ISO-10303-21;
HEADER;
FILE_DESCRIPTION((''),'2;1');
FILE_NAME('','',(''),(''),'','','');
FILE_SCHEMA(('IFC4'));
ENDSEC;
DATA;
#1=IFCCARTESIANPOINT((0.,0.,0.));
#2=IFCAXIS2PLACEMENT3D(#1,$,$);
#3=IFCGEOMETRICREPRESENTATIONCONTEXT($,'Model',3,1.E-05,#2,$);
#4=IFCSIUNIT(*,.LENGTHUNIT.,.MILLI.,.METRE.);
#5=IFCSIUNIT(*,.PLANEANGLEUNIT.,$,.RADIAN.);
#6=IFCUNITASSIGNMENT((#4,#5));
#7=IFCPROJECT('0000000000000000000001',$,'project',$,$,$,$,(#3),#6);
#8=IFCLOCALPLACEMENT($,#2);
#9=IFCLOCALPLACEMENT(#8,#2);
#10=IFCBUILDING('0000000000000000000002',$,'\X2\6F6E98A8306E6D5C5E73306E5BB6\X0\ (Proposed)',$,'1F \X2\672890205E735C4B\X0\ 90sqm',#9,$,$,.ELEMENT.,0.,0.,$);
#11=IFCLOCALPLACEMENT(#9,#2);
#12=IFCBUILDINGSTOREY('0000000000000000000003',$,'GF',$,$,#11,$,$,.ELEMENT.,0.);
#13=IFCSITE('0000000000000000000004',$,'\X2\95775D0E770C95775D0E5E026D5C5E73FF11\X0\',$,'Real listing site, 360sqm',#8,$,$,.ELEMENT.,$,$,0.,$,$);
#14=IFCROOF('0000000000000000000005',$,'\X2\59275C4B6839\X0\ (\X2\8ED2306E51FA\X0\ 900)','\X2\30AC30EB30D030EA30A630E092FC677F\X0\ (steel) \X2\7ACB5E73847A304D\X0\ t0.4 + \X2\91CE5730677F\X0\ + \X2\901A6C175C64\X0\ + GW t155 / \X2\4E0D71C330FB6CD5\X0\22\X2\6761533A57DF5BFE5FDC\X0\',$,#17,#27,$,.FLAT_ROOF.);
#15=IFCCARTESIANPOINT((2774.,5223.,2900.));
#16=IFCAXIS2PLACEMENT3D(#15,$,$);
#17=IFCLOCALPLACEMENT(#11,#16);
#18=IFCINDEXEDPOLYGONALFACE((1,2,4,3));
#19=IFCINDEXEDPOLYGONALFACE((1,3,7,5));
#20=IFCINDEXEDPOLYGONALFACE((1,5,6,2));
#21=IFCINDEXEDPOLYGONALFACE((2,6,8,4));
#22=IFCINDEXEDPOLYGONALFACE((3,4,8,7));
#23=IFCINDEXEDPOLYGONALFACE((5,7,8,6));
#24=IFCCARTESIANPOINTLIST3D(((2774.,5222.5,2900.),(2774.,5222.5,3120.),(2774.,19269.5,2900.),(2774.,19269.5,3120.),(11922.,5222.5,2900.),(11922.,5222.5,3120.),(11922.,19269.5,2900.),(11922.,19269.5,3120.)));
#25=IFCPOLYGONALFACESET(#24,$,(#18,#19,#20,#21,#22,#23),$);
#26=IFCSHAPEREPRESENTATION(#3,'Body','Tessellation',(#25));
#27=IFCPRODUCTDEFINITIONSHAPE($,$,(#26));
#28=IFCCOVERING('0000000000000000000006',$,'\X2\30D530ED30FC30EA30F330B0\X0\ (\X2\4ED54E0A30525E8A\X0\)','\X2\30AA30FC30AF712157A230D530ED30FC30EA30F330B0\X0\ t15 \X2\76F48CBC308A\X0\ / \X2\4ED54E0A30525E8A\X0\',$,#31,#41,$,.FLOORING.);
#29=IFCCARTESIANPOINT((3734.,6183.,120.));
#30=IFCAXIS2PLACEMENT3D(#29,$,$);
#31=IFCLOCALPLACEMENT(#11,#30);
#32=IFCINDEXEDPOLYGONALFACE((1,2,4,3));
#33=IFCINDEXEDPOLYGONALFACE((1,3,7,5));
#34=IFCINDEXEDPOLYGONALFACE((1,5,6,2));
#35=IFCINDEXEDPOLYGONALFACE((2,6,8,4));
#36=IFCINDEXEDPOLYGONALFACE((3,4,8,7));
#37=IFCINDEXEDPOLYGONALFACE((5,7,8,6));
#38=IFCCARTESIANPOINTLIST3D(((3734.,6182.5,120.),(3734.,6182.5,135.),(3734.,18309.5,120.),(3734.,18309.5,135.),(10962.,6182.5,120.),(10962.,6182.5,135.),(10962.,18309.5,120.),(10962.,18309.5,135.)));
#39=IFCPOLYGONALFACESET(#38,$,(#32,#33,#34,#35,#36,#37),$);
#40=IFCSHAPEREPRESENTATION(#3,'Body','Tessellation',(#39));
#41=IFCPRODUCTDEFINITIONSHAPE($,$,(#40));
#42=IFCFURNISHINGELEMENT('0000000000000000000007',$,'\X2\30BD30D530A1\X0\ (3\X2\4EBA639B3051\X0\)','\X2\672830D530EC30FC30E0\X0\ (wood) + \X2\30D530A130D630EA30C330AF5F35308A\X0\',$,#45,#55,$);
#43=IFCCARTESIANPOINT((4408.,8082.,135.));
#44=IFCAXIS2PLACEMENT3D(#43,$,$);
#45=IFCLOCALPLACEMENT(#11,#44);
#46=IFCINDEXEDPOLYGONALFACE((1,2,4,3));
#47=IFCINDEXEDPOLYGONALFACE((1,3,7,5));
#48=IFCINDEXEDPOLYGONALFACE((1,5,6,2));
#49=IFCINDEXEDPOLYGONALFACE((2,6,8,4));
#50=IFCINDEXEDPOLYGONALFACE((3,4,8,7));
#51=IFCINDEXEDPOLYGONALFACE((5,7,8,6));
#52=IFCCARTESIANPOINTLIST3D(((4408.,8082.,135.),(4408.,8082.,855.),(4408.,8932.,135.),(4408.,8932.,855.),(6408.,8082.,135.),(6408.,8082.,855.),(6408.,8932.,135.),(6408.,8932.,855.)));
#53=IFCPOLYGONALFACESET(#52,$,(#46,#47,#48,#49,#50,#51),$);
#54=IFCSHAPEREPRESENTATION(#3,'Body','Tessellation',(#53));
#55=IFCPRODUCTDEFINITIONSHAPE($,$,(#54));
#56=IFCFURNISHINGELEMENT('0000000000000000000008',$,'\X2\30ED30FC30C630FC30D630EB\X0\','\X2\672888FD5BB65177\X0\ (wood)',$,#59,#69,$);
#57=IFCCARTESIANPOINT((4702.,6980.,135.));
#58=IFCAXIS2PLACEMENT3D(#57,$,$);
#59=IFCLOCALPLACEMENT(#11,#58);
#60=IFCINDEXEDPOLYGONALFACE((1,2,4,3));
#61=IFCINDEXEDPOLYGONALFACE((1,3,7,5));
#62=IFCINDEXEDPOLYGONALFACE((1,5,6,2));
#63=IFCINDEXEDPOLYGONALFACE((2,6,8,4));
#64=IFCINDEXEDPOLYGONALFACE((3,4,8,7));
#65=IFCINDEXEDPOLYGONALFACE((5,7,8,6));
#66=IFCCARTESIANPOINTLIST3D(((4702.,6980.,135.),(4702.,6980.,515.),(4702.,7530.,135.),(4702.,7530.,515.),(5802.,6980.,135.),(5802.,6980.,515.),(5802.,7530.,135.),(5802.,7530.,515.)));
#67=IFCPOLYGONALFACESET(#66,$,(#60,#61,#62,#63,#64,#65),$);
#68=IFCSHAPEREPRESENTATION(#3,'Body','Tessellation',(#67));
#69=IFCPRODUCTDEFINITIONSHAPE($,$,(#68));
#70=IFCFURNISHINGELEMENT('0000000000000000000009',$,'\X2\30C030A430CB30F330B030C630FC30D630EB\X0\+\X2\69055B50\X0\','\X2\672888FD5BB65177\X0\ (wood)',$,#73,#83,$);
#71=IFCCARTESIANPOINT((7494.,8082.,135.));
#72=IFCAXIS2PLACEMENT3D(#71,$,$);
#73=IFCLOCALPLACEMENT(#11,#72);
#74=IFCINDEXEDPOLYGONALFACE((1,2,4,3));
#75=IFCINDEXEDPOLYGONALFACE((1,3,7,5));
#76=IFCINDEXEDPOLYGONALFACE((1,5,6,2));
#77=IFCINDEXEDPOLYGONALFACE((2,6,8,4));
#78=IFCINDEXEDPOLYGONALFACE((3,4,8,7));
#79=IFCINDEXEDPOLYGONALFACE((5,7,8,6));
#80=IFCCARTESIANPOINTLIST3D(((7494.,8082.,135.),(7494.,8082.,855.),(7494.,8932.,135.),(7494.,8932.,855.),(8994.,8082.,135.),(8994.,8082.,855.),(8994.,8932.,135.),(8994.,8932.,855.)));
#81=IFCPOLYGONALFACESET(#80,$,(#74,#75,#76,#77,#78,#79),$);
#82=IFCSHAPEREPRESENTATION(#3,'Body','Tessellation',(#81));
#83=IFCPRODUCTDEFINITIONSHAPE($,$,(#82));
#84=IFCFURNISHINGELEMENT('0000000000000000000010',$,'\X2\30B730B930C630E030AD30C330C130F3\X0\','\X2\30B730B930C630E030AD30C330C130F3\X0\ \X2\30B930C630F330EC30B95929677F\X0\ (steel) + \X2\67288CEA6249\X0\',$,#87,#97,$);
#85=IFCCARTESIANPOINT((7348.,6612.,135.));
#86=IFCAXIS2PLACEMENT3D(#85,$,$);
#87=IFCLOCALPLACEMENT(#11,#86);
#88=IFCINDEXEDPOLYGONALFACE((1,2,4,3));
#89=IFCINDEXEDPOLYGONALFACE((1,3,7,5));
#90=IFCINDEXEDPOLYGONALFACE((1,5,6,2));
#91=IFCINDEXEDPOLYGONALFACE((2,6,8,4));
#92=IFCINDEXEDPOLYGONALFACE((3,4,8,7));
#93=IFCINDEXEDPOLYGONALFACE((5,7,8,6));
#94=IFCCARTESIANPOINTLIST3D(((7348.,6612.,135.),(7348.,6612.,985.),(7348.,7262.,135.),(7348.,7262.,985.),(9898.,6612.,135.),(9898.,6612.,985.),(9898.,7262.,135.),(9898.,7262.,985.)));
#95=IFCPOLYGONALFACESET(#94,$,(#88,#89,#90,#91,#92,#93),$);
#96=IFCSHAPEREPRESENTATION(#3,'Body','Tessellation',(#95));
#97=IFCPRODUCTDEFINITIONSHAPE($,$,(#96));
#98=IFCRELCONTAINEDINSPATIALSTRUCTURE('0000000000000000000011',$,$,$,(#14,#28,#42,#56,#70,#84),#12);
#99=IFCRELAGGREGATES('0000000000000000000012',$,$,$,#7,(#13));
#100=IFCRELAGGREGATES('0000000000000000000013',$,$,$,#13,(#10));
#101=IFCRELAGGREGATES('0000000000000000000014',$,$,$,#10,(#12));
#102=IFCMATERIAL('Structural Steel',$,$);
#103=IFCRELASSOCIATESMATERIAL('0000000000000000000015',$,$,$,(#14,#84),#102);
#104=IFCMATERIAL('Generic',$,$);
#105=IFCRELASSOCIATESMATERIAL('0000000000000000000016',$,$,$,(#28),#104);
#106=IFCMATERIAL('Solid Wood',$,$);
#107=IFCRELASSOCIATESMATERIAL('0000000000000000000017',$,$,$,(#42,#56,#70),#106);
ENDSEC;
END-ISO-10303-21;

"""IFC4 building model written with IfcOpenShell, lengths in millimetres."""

from ifc_helpers import new_model, si_unit, frame, frame_2d, origin, place, context, project, spatial, rectangle, extrude, material, element, save


model = new_model("IFC4")

# Units and contexts
model_context = context("Model", 3, precision=1e-05, world=origin())
ifc_project = project(units=[si_unit("LENGTHUNIT", "METRE", prefix="MILLI"), si_unit("PLANEANGLEUNIT", "RADIAN")], contexts=[model_context])

# Site, building, storey
site_placement = place(None, origin())
site = spatial("IfcSite", under=ifc_project, at=site_placement, Name="長崎県長崎市浜平１", ObjectType="Real listing site, 360sqm", CompositionType="ELEMENT", RefElevation=0.0)
building_placement = place(site_placement, origin())
building = spatial("IfcBuilding", under=site, at=building_placement, Name="潮風の浜平の家 (Proposed)", ObjectType="1F 木造平屋 90sqm", CompositionType="ELEMENT", ElevationOfRefHeight=0.0, ElevationOfTerrain=0.0)
storey_placement = place(building_placement, origin())
storey = spatial("IfcBuildingStorey", under=building, at=storey_placement, Name="GF", CompositionType="ELEMENT", Elevation=0.0)

# Shared definitions
ifc_material_1 = material(Name="Solid Wood")

# Roof
ifc_material_2 = material(Name="Structural Steel")
roof_placement = place(storey_placement, frame((2774.0, 5223.0, 2900.0)))
element("IfcRoof", 1, at=roof_placement, inside=storey, material=ifc_material_2, Name="大屋根 (軒の出 900)", Description="ガルバリウム鋼板 (steel) 立平葺き t0.4 + 野地板 + 通気層 + GW t155 / 不燃・法22条区域対応", PredefinedType="FLAT_ROOF", context=model_context, shape_type="SweptSolid", body=[
    extrude(rectangle(XDim=9148.0, YDim=14047.0, at=frame_2d((4574.0, 7023.0))), frame((2774.0, 5223.0, 2900.0)), (0.0, 0.0, 1.0), 220.0),
])

# Covering
ifc_material_3 = material(Name="Generic")
covering_placement = place(storey_placement, frame((3734.0, 6183.0, 120.0)))
element("IfcCovering", 2, at=covering_placement, inside=storey, material=ifc_material_3, Name="フローリング (仕上げ床)", Description="オーク無垢フローリング t15 直貼り / 仕上げ床", PredefinedType="FLOORING", context=model_context, shape_type="SweptSolid", body=[
    extrude(rectangle(XDim=7228.0, YDim=12127.0, at=frame_2d((3614.0, 6063.0))), frame((3734.0, 6183.0, 120.0)), (0.0, 0.0, 1.0), 15.0),
])

# Furnishing elements
furnishing_1_placement = place(storey_placement, frame((4408.0, 8082.0, 135.0)))
element("IfcFurnishingElement", 3, at=furnishing_1_placement, inside=storey, material=ifc_material_1, Name="ソファ (3人掛け)", Description="木フレーム (wood) + ファブリック張り", context=model_context, shape_type="SweptSolid", body=[
    extrude(rectangle(XDim=2000.0, YDim=850.0, at=frame_2d((1000.0, 425.0))), frame((4408.0, 8082.0, 135.0)), (0.0, 0.0, 1.0), 720.0),
])
furnishing_2_placement = place(storey_placement, frame((4702.0, 6980.0, 135.0)))
element("IfcFurnishingElement", 4, at=furnishing_2_placement, inside=storey, material=ifc_material_1, Name="ローテーブル", Description="木製家具 (wood)", context=model_context, shape_type="SweptSolid", body=[
    extrude(rectangle(XDim=1100.0, YDim=550.0, at=frame_2d((550.0, 275.0))), frame((4702.0, 6980.0, 135.0)), (0.0, 0.0, 1.0), 380.0),
])
furnishing_3_placement = place(storey_placement, frame((7494.0, 8082.0, 135.0)))
element("IfcFurnishingElement", 5, at=furnishing_3_placement, inside=storey, material=ifc_material_1, Name="ダイニングテーブル+椅子", Description="木製家具 (wood)", context=model_context, shape_type="SweptSolid", body=[
    extrude(rectangle(XDim=1500.0, YDim=850.0, at=frame_2d((750.0, 425.0))), frame((7494.0, 8082.0, 135.0)), (0.0, 0.0, 1.0), 720.0),
])
furnishing_4_placement = place(storey_placement, frame((7348.0, 6612.0, 135.0)))
element("IfcFurnishingElement", 6, at=furnishing_4_placement, inside=storey, material=ifc_material_2, Name="システムキッチン", Description="システムキッチン ステンレス天板 (steel) + 木質扉", context=model_context, shape_type="SweptSolid", body=[
    extrude(rectangle(XDim=2550.0, YDim=650.0, at=frame_2d((1275.0, 325.0))), frame((7348.0, 6612.0, 135.0)), (0.0, 0.0, 1.0), 850.0),
])

save(model, "model.ifc")
